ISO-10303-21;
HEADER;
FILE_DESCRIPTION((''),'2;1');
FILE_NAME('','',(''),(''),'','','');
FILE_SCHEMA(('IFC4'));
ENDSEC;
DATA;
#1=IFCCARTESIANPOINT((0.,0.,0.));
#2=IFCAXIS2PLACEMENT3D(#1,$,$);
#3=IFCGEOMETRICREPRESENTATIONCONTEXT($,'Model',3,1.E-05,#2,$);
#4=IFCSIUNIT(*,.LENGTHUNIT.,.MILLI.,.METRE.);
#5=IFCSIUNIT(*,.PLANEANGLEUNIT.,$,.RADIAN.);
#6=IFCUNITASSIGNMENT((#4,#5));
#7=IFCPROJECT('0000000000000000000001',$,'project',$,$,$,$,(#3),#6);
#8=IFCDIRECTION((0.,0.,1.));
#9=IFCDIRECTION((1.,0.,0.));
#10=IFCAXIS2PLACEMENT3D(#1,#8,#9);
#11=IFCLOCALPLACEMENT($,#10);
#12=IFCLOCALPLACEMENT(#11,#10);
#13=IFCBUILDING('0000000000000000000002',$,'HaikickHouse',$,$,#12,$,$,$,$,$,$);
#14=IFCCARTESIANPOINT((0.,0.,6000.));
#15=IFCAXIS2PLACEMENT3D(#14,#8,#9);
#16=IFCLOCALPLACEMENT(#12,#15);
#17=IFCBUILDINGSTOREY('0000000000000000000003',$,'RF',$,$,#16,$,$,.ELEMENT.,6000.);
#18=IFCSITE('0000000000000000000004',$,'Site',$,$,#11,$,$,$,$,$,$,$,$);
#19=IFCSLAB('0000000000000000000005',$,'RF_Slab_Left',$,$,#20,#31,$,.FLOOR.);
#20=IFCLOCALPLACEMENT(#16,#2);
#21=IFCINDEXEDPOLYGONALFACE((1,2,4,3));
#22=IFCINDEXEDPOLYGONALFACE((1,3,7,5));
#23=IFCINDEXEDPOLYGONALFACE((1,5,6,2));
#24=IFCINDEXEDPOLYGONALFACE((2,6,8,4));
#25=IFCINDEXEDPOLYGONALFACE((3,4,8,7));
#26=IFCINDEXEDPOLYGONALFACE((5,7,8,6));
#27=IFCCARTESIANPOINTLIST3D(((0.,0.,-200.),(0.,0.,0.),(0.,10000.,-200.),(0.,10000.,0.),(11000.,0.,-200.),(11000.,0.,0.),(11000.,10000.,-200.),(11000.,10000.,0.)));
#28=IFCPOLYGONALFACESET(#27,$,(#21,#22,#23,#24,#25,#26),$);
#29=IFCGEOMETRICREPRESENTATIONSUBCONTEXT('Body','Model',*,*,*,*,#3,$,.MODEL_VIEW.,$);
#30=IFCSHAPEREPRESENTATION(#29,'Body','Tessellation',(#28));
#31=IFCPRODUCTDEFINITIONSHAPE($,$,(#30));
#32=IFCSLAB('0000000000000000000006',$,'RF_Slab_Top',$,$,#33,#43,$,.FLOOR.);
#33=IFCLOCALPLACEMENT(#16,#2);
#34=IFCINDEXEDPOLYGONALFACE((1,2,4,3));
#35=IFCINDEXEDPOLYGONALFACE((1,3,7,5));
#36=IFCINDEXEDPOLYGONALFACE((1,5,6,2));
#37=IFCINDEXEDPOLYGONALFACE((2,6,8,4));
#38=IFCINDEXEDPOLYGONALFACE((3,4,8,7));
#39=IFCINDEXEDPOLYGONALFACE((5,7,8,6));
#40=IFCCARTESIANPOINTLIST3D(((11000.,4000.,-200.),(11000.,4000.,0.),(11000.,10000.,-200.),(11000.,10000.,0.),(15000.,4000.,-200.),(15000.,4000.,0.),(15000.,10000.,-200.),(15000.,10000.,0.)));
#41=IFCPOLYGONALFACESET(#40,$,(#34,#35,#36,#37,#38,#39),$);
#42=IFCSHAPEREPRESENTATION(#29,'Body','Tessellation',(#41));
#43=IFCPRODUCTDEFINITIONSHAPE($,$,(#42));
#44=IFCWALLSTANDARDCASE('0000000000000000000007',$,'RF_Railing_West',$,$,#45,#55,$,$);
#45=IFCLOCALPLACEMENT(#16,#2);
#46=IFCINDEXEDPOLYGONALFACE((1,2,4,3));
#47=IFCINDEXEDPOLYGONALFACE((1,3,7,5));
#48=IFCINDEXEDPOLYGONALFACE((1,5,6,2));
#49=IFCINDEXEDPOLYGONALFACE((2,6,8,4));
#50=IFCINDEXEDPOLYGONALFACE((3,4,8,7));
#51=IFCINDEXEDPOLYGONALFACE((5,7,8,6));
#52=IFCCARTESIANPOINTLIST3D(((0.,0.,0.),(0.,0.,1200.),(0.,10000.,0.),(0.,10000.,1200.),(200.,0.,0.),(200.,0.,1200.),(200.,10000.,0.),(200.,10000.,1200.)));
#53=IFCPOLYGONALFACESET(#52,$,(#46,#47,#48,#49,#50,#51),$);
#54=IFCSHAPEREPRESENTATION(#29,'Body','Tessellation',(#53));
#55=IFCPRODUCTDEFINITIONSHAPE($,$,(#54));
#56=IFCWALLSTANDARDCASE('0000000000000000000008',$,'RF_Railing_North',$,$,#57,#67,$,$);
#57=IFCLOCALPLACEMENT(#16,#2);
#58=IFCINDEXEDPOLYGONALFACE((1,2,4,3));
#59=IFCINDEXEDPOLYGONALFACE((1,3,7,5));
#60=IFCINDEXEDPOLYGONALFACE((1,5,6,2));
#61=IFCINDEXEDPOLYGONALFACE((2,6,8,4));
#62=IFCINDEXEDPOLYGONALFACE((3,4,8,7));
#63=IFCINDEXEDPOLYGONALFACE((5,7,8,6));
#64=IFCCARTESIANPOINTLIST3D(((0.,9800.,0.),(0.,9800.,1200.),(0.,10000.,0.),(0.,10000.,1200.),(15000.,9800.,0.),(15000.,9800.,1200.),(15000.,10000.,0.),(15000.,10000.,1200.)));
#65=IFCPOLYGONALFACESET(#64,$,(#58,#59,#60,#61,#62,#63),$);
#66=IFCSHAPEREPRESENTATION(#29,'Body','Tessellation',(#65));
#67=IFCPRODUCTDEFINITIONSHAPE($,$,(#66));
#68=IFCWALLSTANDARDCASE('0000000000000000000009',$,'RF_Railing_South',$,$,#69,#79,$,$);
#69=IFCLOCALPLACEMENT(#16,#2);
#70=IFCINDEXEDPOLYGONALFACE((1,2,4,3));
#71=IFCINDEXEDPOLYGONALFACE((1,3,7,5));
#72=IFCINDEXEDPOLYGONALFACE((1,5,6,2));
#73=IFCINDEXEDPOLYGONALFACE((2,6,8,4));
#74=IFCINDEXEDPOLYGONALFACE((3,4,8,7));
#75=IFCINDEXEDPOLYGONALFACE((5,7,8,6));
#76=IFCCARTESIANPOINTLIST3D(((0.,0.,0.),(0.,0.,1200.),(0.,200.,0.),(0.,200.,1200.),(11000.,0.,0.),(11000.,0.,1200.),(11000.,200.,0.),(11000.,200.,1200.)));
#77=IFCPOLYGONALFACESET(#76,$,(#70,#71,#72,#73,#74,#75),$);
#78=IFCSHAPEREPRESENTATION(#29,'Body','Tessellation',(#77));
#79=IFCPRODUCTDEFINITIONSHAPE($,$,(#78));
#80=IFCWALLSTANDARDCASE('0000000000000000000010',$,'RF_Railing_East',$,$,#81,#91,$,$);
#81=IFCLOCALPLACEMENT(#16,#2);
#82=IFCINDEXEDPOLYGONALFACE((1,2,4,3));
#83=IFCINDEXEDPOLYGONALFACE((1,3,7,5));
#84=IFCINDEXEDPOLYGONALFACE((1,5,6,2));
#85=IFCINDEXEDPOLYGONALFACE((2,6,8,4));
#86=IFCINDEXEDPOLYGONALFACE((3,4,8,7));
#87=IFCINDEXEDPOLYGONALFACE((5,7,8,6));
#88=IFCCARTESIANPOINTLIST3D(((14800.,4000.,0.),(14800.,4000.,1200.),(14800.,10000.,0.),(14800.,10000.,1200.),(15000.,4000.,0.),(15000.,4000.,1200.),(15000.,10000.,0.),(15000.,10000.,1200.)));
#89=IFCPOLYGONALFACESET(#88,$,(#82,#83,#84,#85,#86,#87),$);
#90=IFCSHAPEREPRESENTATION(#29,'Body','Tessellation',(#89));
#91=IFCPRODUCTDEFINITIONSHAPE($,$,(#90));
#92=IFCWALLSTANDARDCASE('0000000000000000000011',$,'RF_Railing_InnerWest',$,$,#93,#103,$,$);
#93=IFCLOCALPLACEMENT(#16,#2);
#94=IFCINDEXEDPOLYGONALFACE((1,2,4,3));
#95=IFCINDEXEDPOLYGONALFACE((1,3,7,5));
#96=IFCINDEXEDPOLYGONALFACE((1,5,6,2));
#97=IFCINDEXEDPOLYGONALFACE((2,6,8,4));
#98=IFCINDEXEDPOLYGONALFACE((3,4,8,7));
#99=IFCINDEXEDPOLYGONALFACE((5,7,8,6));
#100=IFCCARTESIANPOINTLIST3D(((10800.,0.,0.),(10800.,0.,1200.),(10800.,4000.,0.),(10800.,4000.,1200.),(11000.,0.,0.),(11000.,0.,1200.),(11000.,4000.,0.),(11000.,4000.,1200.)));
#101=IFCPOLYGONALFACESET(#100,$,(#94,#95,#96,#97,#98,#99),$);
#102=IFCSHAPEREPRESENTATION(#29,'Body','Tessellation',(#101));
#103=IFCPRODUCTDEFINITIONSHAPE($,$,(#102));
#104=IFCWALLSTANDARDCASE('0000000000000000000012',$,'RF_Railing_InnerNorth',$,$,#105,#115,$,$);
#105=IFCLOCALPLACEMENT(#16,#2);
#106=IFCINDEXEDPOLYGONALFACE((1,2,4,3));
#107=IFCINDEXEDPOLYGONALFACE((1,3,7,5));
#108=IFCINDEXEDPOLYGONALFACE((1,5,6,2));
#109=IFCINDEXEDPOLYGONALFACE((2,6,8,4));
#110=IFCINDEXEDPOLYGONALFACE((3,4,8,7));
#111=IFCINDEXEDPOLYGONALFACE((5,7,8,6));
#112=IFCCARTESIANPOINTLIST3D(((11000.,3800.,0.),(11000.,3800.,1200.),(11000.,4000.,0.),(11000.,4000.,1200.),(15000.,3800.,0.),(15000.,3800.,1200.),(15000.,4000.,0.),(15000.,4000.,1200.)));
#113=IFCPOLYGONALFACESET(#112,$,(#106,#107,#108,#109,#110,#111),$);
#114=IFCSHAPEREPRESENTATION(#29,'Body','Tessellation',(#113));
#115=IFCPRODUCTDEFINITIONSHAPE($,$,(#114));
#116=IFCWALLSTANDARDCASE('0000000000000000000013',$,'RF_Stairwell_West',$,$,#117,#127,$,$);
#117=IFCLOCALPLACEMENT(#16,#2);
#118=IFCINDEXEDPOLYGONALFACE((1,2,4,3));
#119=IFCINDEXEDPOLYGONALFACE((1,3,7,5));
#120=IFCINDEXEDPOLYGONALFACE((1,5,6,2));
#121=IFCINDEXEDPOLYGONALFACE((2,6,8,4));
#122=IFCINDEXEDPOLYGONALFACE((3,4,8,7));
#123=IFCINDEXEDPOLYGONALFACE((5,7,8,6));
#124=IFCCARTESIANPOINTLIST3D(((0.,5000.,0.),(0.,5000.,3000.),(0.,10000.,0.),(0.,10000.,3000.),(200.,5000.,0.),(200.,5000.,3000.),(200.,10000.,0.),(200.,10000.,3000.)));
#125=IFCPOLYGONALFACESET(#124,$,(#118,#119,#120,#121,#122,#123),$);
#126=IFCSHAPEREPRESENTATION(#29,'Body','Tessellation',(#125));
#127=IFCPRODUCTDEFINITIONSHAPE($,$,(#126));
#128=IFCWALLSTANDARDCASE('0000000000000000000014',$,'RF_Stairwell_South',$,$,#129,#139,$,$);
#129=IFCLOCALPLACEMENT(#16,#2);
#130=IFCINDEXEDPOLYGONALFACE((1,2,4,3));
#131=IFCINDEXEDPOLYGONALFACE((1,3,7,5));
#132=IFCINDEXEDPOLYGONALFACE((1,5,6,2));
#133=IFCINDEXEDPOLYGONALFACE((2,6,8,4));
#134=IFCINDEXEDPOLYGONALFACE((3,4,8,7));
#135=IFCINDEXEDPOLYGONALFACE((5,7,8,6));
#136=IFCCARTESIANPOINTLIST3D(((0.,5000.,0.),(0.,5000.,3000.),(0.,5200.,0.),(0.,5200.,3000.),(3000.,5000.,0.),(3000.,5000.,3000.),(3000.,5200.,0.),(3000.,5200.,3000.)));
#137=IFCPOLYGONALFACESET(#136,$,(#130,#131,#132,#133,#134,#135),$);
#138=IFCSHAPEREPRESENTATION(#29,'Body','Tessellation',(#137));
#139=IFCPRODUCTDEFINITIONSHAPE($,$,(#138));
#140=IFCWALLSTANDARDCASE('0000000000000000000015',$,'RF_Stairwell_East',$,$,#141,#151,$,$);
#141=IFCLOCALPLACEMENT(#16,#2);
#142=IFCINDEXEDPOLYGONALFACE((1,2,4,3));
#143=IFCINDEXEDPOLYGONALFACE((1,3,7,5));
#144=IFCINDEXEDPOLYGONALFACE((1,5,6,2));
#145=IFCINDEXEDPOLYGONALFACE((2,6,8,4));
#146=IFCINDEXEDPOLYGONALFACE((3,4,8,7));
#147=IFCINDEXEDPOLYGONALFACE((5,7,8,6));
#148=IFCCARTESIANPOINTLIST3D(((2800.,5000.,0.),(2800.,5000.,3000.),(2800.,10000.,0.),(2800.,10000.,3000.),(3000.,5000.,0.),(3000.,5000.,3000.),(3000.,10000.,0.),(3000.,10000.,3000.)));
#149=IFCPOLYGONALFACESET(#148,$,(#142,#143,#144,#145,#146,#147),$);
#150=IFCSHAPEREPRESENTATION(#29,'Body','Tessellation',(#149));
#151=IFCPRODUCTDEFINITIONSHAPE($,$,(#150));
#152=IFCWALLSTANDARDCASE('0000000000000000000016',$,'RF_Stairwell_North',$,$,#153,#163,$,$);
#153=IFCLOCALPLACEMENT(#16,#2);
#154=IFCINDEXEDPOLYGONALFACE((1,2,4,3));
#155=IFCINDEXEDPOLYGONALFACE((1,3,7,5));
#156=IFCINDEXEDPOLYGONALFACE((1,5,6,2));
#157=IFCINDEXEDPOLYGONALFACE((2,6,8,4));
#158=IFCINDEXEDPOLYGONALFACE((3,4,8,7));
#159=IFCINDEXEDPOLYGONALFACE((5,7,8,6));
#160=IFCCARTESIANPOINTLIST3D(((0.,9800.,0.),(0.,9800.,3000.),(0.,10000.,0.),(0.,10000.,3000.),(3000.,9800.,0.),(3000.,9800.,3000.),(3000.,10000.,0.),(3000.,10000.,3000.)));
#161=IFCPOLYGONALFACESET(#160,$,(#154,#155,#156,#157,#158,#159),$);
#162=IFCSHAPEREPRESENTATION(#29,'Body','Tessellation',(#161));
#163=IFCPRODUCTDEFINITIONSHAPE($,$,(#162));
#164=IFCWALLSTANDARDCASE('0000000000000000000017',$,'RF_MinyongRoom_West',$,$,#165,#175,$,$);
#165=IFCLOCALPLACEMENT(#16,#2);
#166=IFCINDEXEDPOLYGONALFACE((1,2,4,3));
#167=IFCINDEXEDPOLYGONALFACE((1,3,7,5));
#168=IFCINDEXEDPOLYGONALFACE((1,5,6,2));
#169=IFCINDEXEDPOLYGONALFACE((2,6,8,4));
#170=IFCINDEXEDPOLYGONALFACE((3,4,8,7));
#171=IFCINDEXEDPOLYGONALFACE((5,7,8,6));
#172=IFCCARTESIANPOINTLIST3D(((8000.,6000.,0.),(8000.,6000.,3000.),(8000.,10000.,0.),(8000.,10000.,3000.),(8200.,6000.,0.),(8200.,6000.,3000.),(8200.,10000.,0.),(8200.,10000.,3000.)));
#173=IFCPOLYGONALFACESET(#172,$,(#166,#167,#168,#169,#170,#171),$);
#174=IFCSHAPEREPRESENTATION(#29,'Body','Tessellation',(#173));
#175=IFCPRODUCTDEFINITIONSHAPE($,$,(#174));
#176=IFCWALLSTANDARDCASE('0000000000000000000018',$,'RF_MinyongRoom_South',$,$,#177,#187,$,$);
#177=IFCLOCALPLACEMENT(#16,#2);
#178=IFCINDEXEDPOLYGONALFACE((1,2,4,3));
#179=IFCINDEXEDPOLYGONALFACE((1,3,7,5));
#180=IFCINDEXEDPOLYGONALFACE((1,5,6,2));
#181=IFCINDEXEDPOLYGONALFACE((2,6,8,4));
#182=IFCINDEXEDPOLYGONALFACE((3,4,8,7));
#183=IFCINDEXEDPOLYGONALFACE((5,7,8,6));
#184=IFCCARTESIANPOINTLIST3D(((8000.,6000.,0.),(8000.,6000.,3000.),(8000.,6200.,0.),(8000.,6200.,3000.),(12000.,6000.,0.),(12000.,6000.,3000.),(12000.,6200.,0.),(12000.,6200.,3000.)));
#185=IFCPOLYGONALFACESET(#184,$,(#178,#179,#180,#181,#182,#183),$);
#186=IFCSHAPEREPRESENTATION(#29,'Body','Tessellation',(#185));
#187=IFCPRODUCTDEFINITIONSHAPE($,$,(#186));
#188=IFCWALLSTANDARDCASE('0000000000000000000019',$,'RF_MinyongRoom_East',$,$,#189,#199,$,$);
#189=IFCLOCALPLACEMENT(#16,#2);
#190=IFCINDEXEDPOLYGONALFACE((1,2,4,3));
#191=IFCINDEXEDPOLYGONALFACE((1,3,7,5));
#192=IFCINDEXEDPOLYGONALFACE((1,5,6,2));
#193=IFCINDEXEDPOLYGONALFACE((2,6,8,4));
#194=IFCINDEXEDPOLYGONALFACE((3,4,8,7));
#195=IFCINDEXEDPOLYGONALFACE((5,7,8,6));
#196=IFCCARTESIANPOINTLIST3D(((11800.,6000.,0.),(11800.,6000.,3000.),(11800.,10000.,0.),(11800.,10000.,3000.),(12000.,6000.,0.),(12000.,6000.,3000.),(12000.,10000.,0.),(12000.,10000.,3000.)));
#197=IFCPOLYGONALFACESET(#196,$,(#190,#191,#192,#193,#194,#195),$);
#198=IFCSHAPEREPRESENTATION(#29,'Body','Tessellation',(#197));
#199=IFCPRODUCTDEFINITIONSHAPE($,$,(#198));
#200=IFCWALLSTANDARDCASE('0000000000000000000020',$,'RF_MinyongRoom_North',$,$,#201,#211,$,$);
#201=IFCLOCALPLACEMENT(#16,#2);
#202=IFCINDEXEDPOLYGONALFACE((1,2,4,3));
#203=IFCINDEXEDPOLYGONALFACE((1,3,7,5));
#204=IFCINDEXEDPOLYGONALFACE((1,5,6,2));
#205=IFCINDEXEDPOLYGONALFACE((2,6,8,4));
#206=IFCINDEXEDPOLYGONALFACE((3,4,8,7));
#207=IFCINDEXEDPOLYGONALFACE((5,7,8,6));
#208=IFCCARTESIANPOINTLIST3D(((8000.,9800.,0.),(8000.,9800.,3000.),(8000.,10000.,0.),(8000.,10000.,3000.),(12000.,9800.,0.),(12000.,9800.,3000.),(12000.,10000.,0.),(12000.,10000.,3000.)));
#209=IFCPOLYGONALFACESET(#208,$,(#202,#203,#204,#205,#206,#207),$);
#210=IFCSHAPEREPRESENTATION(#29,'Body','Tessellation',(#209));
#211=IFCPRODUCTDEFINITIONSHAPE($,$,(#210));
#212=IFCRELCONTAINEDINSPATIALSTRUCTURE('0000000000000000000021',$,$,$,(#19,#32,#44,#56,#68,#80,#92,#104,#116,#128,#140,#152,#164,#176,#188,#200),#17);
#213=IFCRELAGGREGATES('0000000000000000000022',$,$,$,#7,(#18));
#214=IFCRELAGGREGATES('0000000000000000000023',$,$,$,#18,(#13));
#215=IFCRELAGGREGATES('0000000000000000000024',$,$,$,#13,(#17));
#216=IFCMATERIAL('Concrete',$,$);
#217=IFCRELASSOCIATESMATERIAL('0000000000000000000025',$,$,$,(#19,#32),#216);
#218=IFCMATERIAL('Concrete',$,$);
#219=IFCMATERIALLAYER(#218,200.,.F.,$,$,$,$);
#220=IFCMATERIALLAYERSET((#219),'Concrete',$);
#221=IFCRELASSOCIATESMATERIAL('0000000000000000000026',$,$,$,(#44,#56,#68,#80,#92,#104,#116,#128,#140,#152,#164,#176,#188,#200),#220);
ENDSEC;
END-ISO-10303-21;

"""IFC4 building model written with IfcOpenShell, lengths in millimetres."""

from ifc_helpers import new_model, si_unit, frame, origin, origin_with_axes, place, context, subcontext, project, spatial, rectangle, extrude, material, layer, layer_set, layer_usage, element, save


model = new_model("IFC4")

# Units and contexts
model_context = context("Model", 3, precision=1e-05, world=origin())
body_context = subcontext(model_context, "Body", "Model", "MODEL_VIEW")
ifc_project = project(units=[si_unit("LENGTHUNIT", "METRE", prefix="MILLI"), si_unit("PLANEANGLEUNIT", "RADIAN")], contexts=[model_context])

# Site, building, storey
site_placement = place(None, origin_with_axes())
site = spatial("IfcSite", under=ifc_project, at=site_placement, Name="Site")
building_placement = place(site_placement, origin_with_axes())
building = spatial("IfcBuilding", under=site, at=building_placement, Name="HaikickHouse")
storey_placement = place(building_placement, frame((0.0, 0.0, 6000.0), z_axis=(0.0, 0.0, 1.0), x_axis=(1.0, 0.0, 0.0)))
storey = spatial("IfcBuildingStorey", under=building, at=storey_placement, Name="RF", CompositionType="ELEMENT", Elevation=6000.0)

# Slabs
ifc_material_1 = material(Name="Concrete")
slab_1_placement = place(None, frame((0.0, 0.0, 5800.0), z_axis=(0.0, 0.0, 1.0), x_axis=(1.0, 0.0, 0.0)))
element("IfcSlab", 1, at=slab_1_placement, inside=storey, material=ifc_material_1, Name="RF_Slab_Left", PredefinedType="FLOOR", context=body_context, shape_type="SweptSolid", body=[
    extrude(rectangle(XDim=11000.0, YDim=10000.0), frame((5500.0, 5000.0, 0.0)), (0.0, 0.0, 1.0), 200.0),
])
slab_2_placement = place(None, frame((11000.0, 4000.0, 5800.0), z_axis=(0.0, 0.0, 1.0), x_axis=(1.0, 0.0, 0.0)))
element("IfcSlab", 2, at=slab_2_placement, inside=storey, material=ifc_material_1, Name="RF_Slab_Top", PredefinedType="FLOOR", context=body_context, shape_type="SweptSolid", body=[
    extrude(rectangle(XDim=4000.0, YDim=6000.0), frame((2000.0, 3000.0, 0.0)), (0.0, 0.0, 1.0), 200.0),
])

# Walls
ifc_material_2 = material(Name="Concrete")
ifc_layer = layer(ifc_material_2, 200.0, ventilated=False)
ifc_layer_set = layer_set([ifc_layer], Name="Concrete")
ifc_layer_usage = layer_usage(ifc_layer_set, "AXIS2", "POSITIVE", 0.0)
wall_1_placement = place(None, frame((0.0, 0.0, 6000.0), z_axis=(0.0, 0.0, 1.0), x_axis=(1.0, 0.0, 0.0)))
element("IfcWallStandardCase", 3, at=wall_1_placement, inside=storey, material=ifc_layer_usage, Name="RF_Railing_West", context=body_context, shape_type="SweptSolid", body=[
    extrude(rectangle(XDim=200.0, YDim=10000.0), frame((100.0, 5000.0, 0.0)), (0.0, 0.0, 1.0), 1200.0),
])
wall_2_placement = place(None, frame((0.0, 9800.0, 6000.0), z_axis=(0.0, 0.0, 1.0), x_axis=(1.0, 0.0, 0.0)))
element("IfcWallStandardCase", 4, at=wall_2_placement, inside=storey, material=ifc_layer_usage, Name="RF_Railing_North", context=body_context, shape_type="SweptSolid", body=[
    extrude(rectangle(XDim=15000.0, YDim=200.0), frame((7500.0, 100.0, 0.0)), (0.0, 0.0, 1.0), 1200.0),
])
wall_3_placement = place(None, frame((0.0, 0.0, 6000.0), z_axis=(0.0, 0.0, 1.0), x_axis=(1.0, 0.0, 0.0)))
element("IfcWallStandardCase", 5, at=wall_3_placement, inside=storey, material=ifc_layer_usage, Name="RF_Railing_South", context=body_context, shape_type="SweptSolid", body=[
    extrude(rectangle(XDim=11000.0, YDim=200.0), frame((5500.0, 100.0, 0.0)), (0.0, 0.0, 1.0), 1200.0),
])
wall_4_placement = place(None, frame((14800.0, 4000.0, 6000.0), z_axis=(0.0, 0.0, 1.0), x_axis=(1.0, 0.0, 0.0)))
element("IfcWallStandardCase", 6, at=wall_4_placement, inside=storey, material=ifc_layer_usage, Name="RF_Railing_East", context=body_context, shape_type="SweptSolid", body=[
    extrude(rectangle(XDim=200.0, YDim=6000.0), frame((100.0, 3000.0, 0.0)), (0.0, 0.0, 1.0), 1200.0),
])
wall_5_placement = place(None, frame((10800.0, 0.0, 6000.0), z_axis=(0.0, 0.0, 1.0), x_axis=(1.0, 0.0, 0.0)))
element("IfcWallStandardCase", 7, at=wall_5_placement, inside=storey, material=ifc_layer_usage, Name="RF_Railing_InnerWest", context=body_context, shape_type="SweptSolid", body=[
    extrude(rectangle(XDim=200.0, YDim=4000.0), frame((100.0, 2000.0, 0.0)), (0.0, 0.0, 1.0), 1200.0),
])
wall_6_placement = place(None, frame((11000.0, 3800.0, 6000.0), z_axis=(0.0, 0.0, 1.0), x_axis=(1.0, 0.0, 0.0)))
element("IfcWallStandardCase", 8, at=wall_6_placement, inside=storey, material=ifc_layer_usage, Name="RF_Railing_InnerNorth", context=body_context, shape_type="SweptSolid", body=[
    extrude(rectangle(XDim=4000.0, YDim=200.0), frame((2000.0, 100.0, 0.0)), (0.0, 0.0, 1.0), 1200.0),
])
wall_7_placement = place(None, frame((0.0, 5000.0, 6000.0), z_axis=(0.0, 0.0, 1.0), x_axis=(1.0, 0.0, 0.0)))
element("IfcWallStandardCase", 9, at=wall_7_placement, inside=storey, material=ifc_layer_usage, Name="RF_Stairwell_West", context=body_context, shape_type="SweptSolid", body=[
    extrude(rectangle(XDim=200.0, YDim=5000.0), frame((100.0, 2500.0, 0.0)), (0.0, 0.0, 1.0), 3000.0),
])
wall_8_placement = place(None, frame((0.0, 5000.0, 6000.0), z_axis=(0.0, 0.0, 1.0), x_axis=(1.0, 0.0, 0.0)))
element("IfcWallStandardCase", 10, at=wall_8_placement, inside=storey, material=ifc_layer_usage, Name="RF_Stairwell_South", context=body_context, shape_type="SweptSolid", body=[
    extrude(rectangle(XDim=3000.0, YDim=200.0), frame((1500.0, 100.0, 0.0)), (0.0, 0.0, 1.0), 3000.0),
])
wall_9_placement = place(None, frame((2800.0, 5000.0, 6000.0), z_axis=(0.0, 0.0, 1.0), x_axis=(1.0, 0.0, 0.0)))
element("IfcWallStandardCase", 11, at=wall_9_placement, inside=storey, material=ifc_layer_usage, Name="RF_Stairwell_East", context=body_context, shape_type="SweptSolid", body=[
    extrude(rectangle(XDim=200.0, YDim=5000.0), frame((100.0, 2500.0, 0.0)), (0.0, 0.0, 1.0), 3000.0),
])
wall_10_placement = place(None, frame((0.0, 9800.0, 6000.0), z_axis=(0.0, 0.0, 1.0), x_axis=(1.0, 0.0, 0.0)))
element("IfcWallStandardCase", 12, at=wall_10_placement, inside=storey, material=ifc_layer_usage, Name="RF_Stairwell_North", context=body_context, shape_type="SweptSolid", body=[
    extrude(rectangle(XDim=3000.0, YDim=200.0), frame((1500.0, 100.0, 0.0)), (0.0, 0.0, 1.0), 3000.0),
])
wall_11_placement = place(None, frame((8000.0, 6000.0, 6000.0), z_axis=(0.0, 0.0, 1.0), x_axis=(1.0, 0.0, 0.0)))
element("IfcWallStandardCase", 13, at=wall_11_placement, inside=storey, material=ifc_layer_usage, Name="RF_MinyongRoom_West", context=body_context, shape_type="SweptSolid", body=[
    extrude(rectangle(XDim=200.0, YDim=4000.0), frame((100.0, 2000.0, 0.0)), (0.0, 0.0, 1.0), 3000.0),
])
wall_12_placement = place(None, frame((8000.0, 6000.0, 6000.0), z_axis=(0.0, 0.0, 1.0), x_axis=(1.0, 0.0, 0.0)))
element("IfcWallStandardCase", 14, at=wall_12_placement, inside=storey, material=ifc_layer_usage, Name="RF_MinyongRoom_South", context=body_context, shape_type="SweptSolid", body=[
    extrude(rectangle(XDim=4000.0, YDim=200.0), frame((2000.0, 100.0, 0.0)), (0.0, 0.0, 1.0), 3000.0),
])
wall_13_placement = place(None, frame((11800.0, 6000.0, 6000.0), z_axis=(0.0, 0.0, 1.0), x_axis=(1.0, 0.0, 0.0)))
element("IfcWallStandardCase", 15, at=wall_13_placement, inside=storey, material=ifc_layer_usage, Name="RF_MinyongRoom_East", context=body_context, shape_type="SweptSolid", body=[
    extrude(rectangle(XDim=200.0, YDim=4000.0), frame((100.0, 2000.0, 0.0)), (0.0, 0.0, 1.0), 3000.0),
])
wall_14_placement = place(None, frame((8000.0, 9800.0, 6000.0), z_axis=(0.0, 0.0, 1.0), x_axis=(1.0, 0.0, 0.0)))
element("IfcWallStandardCase", 16, at=wall_14_placement, inside=storey, material=ifc_layer_usage, Name="RF_MinyongRoom_North", context=body_context, shape_type="SweptSolid", body=[
    extrude(rectangle(XDim=4000.0, YDim=200.0), frame((2000.0, 100.0, 0.0)), (0.0, 0.0, 1.0), 3000.0),
])

save(model, "model.ifc")
